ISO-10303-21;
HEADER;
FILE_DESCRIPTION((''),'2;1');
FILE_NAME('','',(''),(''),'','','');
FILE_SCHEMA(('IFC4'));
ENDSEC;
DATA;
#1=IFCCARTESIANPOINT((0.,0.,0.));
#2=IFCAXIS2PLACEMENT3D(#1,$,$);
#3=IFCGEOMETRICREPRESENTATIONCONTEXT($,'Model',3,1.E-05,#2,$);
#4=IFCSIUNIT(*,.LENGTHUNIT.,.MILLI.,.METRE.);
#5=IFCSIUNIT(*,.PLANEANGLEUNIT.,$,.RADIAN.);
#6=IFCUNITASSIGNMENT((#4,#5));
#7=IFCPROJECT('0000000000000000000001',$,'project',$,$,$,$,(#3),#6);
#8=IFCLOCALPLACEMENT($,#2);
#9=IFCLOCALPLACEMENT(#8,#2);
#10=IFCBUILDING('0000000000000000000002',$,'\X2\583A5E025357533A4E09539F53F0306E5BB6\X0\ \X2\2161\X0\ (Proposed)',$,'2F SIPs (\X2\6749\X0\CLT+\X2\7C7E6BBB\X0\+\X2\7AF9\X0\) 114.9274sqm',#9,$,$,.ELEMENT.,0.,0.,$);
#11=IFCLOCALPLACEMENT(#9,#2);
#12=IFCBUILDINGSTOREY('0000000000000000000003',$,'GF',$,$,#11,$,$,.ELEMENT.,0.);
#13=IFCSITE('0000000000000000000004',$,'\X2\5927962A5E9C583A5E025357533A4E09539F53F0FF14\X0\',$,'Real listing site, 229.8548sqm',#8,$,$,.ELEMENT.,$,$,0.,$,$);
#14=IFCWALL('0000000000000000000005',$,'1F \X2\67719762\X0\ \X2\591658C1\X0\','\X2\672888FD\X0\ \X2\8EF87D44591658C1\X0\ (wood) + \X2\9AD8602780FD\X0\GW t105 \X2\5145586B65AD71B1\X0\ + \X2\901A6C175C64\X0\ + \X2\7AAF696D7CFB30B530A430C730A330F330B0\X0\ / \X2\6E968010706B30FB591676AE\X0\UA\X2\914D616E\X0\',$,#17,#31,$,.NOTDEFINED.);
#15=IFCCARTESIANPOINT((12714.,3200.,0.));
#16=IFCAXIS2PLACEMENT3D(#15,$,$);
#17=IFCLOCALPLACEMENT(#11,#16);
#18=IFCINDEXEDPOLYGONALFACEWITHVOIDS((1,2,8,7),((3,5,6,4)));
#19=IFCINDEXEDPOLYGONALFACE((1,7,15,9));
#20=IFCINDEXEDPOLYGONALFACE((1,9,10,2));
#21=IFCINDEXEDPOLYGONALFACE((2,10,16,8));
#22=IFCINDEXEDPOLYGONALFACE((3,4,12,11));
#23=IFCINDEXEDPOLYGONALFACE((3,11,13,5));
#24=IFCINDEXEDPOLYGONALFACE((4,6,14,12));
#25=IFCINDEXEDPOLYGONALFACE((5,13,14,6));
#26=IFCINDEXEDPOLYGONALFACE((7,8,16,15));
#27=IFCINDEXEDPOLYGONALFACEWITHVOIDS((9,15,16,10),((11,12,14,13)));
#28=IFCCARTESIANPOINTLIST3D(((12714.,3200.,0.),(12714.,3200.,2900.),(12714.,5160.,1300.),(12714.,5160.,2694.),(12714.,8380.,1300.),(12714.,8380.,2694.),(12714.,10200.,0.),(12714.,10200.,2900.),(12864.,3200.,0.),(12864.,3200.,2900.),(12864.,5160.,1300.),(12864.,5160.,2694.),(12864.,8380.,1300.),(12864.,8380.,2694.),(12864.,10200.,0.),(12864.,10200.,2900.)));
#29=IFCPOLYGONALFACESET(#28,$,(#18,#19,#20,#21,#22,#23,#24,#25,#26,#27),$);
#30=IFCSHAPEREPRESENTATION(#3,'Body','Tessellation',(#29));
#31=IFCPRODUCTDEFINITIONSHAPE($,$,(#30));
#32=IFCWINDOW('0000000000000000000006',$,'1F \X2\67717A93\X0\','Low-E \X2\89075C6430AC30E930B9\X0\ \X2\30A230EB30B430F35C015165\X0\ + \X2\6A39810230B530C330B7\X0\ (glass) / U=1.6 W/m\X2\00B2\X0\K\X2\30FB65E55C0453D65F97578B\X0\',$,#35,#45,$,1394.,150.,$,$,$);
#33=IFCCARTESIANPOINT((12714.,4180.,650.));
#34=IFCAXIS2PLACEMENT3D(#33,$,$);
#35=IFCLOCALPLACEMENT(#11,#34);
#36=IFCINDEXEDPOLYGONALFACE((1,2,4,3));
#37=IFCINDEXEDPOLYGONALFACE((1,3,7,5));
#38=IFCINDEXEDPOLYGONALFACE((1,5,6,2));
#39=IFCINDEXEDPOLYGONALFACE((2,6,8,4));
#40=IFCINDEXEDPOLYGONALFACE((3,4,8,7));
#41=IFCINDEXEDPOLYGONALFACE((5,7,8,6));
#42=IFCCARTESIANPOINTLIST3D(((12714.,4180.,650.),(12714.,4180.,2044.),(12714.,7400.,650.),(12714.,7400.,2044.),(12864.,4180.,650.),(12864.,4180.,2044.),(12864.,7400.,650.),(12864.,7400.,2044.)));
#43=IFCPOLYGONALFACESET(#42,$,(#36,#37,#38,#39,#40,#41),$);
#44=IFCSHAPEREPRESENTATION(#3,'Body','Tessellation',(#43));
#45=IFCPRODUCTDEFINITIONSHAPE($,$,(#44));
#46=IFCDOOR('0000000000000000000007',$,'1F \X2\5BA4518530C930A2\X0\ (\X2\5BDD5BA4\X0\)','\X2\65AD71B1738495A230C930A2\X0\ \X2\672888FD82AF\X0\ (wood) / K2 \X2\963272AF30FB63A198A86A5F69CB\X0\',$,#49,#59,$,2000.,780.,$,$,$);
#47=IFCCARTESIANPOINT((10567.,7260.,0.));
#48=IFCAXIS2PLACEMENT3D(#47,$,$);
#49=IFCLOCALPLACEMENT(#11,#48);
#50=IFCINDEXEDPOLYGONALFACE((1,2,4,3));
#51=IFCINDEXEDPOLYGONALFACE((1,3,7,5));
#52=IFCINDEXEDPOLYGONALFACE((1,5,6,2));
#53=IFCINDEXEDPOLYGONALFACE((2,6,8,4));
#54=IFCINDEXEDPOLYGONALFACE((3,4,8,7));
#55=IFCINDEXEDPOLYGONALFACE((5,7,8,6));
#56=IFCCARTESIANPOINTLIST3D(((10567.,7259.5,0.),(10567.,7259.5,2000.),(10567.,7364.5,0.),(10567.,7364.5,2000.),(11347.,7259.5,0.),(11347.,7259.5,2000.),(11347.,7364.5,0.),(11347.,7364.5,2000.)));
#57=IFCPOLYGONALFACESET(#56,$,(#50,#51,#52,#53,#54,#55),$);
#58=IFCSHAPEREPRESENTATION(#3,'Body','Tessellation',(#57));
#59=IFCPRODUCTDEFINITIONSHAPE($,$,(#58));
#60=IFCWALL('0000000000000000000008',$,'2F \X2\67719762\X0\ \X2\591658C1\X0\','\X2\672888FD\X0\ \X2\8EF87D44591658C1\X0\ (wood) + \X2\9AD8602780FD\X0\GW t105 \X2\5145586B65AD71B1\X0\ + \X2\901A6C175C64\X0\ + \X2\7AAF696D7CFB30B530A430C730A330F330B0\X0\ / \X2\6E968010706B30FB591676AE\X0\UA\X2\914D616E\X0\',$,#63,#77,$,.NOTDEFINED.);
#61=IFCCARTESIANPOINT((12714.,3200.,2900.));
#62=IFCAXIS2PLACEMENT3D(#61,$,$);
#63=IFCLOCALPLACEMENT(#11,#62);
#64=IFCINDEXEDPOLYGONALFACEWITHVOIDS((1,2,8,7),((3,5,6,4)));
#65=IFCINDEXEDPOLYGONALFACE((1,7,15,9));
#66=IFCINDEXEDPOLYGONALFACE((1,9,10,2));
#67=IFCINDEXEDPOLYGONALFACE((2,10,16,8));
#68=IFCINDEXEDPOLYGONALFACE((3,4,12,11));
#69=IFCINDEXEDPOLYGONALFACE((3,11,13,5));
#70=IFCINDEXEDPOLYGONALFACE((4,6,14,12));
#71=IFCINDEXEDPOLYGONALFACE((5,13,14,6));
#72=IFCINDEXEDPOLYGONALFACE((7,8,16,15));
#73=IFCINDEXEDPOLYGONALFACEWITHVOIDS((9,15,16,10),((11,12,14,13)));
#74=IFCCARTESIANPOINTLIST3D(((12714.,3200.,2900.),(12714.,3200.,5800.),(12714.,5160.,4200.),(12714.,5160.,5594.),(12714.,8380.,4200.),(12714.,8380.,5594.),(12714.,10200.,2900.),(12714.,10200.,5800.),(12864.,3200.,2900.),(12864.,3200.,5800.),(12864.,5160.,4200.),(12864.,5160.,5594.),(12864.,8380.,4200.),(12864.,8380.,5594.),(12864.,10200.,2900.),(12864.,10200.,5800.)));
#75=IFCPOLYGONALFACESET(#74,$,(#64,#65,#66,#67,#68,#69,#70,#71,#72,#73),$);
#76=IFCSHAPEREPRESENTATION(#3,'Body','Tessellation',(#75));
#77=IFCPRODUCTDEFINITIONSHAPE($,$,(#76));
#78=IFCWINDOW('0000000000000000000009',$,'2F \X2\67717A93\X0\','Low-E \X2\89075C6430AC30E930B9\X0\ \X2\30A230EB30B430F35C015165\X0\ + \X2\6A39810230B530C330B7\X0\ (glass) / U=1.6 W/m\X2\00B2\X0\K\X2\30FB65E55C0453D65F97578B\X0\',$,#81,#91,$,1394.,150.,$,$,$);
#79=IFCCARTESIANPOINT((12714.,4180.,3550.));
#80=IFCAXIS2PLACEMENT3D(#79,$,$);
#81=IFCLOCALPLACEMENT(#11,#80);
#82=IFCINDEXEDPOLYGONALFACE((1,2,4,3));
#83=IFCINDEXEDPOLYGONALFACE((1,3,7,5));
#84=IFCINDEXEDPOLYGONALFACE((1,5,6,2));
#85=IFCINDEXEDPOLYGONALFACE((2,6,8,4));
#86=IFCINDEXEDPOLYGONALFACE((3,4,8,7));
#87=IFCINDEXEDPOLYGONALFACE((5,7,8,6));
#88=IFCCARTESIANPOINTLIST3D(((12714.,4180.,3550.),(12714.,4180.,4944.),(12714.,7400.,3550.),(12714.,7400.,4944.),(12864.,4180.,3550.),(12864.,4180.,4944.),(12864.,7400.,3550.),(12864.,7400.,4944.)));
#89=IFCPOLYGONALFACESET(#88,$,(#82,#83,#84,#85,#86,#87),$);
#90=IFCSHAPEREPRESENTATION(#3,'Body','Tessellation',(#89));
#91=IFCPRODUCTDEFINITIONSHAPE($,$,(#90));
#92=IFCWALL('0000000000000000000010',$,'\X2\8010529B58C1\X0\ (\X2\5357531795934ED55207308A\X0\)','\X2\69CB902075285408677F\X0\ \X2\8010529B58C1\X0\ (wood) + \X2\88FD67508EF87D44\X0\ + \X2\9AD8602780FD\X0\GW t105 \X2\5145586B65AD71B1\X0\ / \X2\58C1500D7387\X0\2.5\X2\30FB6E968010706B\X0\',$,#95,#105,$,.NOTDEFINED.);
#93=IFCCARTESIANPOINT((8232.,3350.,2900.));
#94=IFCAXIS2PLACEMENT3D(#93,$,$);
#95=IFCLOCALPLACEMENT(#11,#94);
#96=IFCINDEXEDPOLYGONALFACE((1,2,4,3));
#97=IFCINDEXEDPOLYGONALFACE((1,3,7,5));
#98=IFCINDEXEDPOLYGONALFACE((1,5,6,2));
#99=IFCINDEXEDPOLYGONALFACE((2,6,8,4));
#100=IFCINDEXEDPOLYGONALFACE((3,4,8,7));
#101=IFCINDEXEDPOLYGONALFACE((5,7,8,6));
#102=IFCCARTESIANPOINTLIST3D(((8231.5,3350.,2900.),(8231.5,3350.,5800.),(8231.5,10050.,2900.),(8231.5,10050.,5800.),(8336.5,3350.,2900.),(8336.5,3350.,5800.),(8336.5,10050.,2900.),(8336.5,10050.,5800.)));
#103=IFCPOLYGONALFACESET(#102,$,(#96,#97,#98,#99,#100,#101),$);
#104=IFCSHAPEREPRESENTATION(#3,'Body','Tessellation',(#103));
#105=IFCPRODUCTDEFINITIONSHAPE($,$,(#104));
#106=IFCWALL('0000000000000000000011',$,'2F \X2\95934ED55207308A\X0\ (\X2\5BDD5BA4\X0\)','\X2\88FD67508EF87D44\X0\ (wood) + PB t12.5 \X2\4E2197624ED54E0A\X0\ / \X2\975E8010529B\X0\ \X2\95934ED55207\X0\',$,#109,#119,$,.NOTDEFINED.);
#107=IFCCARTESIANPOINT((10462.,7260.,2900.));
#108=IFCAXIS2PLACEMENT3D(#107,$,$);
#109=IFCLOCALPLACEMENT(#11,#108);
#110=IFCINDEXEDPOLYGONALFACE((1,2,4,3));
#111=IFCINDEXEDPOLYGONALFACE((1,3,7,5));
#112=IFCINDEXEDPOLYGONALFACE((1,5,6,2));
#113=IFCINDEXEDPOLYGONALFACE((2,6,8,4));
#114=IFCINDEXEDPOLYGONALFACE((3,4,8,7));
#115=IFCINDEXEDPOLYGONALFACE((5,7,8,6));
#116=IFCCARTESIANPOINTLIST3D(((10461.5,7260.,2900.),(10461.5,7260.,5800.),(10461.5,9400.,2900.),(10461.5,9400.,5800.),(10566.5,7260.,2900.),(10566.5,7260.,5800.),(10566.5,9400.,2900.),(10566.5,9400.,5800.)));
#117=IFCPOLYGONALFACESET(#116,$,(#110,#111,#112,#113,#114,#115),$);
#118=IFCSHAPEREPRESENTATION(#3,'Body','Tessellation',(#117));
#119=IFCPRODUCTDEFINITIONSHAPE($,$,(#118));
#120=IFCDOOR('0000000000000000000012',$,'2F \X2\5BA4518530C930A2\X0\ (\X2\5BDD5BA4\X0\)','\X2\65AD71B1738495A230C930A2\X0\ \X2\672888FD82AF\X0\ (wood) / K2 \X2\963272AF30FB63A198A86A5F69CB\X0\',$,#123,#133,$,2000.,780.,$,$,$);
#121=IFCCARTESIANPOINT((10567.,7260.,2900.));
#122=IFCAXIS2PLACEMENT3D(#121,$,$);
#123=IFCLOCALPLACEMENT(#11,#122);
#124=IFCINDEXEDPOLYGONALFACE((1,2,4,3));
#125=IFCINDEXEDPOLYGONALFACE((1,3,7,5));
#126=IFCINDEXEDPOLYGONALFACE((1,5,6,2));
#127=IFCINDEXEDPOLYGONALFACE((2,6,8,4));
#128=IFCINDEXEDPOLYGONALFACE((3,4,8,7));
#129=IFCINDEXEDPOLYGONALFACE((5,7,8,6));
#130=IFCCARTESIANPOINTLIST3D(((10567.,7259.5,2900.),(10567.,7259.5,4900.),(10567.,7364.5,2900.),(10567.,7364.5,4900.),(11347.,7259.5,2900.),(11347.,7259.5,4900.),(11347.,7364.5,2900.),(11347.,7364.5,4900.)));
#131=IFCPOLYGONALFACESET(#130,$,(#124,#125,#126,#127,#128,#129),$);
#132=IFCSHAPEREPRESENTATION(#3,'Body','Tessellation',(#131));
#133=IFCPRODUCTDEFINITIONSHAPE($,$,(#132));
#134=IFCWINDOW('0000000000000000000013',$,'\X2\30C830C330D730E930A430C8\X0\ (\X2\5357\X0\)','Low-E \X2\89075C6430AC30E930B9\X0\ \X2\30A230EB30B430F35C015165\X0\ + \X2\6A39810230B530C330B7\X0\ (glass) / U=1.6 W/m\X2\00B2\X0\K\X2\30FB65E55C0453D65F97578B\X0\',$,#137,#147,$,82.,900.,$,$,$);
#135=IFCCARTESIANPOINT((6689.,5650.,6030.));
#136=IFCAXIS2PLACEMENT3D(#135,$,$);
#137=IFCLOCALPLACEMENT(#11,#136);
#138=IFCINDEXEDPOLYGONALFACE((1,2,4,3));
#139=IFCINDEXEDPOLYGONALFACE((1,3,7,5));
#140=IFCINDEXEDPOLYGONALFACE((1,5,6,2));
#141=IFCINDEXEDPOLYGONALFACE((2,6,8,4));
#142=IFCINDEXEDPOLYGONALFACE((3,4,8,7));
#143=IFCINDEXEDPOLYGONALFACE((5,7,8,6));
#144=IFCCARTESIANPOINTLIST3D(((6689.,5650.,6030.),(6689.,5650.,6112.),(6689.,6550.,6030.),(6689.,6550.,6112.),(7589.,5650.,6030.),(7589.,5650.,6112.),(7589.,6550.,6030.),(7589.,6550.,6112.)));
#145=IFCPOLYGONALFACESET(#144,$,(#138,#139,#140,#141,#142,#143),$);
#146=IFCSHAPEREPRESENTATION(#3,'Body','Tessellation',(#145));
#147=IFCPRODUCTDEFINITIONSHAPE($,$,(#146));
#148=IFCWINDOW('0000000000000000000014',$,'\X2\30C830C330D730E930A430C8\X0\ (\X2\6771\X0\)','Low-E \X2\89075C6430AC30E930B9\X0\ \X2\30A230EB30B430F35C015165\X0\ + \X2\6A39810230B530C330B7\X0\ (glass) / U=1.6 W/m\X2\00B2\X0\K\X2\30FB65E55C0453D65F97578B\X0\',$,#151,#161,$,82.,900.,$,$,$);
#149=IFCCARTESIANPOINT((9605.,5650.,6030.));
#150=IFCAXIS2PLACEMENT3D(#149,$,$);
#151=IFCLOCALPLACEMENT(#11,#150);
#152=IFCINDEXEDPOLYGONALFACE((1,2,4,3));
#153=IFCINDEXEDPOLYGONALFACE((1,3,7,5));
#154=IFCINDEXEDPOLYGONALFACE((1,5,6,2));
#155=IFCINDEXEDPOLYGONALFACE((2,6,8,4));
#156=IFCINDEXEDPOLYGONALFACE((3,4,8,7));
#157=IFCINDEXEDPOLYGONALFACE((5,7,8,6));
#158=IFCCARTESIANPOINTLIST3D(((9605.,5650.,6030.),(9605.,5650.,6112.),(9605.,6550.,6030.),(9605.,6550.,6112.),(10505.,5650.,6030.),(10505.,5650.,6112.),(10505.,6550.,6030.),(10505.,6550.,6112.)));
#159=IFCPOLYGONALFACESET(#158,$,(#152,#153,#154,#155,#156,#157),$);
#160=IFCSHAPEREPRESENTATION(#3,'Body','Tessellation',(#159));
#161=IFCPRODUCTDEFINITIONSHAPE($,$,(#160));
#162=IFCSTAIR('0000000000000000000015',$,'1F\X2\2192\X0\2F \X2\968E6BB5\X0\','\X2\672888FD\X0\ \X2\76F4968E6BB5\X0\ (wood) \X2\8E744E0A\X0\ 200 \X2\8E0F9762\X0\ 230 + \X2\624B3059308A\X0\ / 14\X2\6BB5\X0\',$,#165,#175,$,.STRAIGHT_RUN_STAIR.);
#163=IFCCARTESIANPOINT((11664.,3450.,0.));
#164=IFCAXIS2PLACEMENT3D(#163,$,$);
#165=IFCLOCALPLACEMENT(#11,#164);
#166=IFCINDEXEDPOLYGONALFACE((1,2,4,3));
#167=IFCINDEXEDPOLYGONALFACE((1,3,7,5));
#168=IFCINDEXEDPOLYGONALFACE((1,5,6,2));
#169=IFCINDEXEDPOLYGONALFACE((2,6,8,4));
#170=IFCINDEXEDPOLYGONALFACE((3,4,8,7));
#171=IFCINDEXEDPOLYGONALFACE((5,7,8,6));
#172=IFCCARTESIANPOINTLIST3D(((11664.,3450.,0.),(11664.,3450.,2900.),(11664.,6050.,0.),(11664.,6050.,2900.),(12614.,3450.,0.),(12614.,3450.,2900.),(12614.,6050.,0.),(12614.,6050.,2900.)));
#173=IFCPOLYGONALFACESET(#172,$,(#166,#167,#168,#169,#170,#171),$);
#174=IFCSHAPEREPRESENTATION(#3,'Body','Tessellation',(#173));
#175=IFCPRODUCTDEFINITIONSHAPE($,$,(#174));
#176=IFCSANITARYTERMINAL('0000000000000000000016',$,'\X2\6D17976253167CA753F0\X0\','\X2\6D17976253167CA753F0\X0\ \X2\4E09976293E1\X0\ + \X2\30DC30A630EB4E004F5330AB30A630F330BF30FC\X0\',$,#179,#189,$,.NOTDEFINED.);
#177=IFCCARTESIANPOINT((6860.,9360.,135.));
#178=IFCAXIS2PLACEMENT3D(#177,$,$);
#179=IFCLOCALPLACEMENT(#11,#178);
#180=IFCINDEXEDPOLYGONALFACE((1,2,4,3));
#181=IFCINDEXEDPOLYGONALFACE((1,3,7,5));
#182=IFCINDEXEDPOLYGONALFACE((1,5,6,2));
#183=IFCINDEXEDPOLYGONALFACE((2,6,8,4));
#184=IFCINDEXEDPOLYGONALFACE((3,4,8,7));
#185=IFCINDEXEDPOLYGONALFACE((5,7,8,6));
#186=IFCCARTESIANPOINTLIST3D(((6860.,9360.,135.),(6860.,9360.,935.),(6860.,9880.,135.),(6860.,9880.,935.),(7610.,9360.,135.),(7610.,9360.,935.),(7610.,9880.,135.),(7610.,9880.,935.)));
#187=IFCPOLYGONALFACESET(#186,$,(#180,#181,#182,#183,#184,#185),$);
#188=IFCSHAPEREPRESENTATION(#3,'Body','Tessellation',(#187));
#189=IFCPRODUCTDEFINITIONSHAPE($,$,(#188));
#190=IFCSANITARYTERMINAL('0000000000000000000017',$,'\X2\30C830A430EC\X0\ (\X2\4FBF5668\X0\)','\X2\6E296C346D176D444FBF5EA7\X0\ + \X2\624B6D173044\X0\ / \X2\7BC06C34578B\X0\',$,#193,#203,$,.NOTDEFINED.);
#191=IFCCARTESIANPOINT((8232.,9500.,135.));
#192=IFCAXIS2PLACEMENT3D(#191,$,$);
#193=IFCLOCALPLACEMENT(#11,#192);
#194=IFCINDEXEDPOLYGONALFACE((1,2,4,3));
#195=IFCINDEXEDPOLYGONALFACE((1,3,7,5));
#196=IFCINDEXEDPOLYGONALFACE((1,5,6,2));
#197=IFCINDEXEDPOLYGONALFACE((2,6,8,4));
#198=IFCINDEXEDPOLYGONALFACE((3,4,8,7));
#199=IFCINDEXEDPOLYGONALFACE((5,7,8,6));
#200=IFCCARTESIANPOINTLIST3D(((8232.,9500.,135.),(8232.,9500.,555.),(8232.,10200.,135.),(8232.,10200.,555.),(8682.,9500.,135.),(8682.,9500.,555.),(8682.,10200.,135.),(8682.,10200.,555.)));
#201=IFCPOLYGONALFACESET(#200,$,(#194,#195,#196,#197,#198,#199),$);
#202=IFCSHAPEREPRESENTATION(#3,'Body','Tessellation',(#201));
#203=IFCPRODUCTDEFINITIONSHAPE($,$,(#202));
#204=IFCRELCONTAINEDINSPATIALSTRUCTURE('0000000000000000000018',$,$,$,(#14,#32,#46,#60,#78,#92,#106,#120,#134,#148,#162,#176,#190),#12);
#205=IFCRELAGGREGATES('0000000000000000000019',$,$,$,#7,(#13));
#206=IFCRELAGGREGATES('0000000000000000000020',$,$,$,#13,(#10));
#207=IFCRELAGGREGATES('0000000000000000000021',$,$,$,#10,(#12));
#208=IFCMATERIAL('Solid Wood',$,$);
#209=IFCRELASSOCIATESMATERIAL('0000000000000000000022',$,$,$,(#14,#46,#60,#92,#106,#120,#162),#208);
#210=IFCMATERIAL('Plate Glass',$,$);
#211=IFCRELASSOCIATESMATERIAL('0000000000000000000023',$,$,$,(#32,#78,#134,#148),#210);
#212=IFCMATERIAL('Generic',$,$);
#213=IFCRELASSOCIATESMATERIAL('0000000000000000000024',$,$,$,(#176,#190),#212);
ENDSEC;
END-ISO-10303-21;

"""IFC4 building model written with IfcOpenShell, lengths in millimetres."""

from ifc_helpers import new_model, si_unit, frame, frame_2d, origin, place, context, project, spatial, rectangle, extrude, material, element, fill, save


model = new_model("IFC4")

# Units and contexts
model_context = context("Model", 3, precision=1e-05, world=origin())
ifc_project = project(units=[si_unit("LENGTHUNIT", "METRE", prefix="MILLI"), si_unit("PLANEANGLEUNIT", "RADIAN")], contexts=[model_context])

# Site, building, storey
site_placement = place(None, origin())
site = spatial("IfcSite", under=ifc_project, at=site_placement, Name="大阪府堺市南区三原台４", ObjectType="Real listing site, 229.8548sqm", CompositionType="ELEMENT", RefElevation=0.0)
building_placement = place(site_placement, origin())
building = spatial("IfcBuilding", under=site, at=building_placement, Name="堺市南区三原台の家 Ⅱ (Proposed)", ObjectType="2F SIPs (杉CLT+籾殻+竹) 114.9274sqm", CompositionType="ELEMENT", ElevationOfRefHeight=0.0, ElevationOfTerrain=0.0)
storey_placement = place(building_placement, origin())
storey = spatial("IfcBuildingStorey", under=building, at=storey_placement, Name="GF", CompositionType="ELEMENT", Elevation=0.0)

# Wall, opening, window
ifc_material_1 = material(Name="Solid Wood")
wall_1_placement = place(storey_placement, frame((12714.0, 3200.0, 0.0)))
wall_1 = element("IfcWall", 1, at=wall_1_placement, inside=storey, material=ifc_material_1, Name="1F 東面 外壁", Description="木製 軸組外壁 (wood) + 高性能GW t105 充填断熱 + 通気層 + 窯業系サイディング / 準耐火・外皮UA配慮", PredefinedType="NOTDEFINED", context=model_context, shape_type="SweptSolid", body=[
    extrude(rectangle(XDim=150.0, YDim=7000.0, at=frame_2d((75.0, 3500.0))), frame((12714.0, 3200.0, 0.0)), (0.0, 0.0, 1.0), 2900.0),
])
opening_1_placement = place(storey_placement, frame((12714.0, 4180.0, 650.0)))
opening_1 = element("IfcOpeningElement", 2, at=opening_1_placement, cuts=wall_1, PredefinedType="NOTDEFINED", context=model_context, shape_type="SweptSolid", body=[
    extrude(rectangle(XDim=150.0, YDim=3220.0, at=frame_2d((75.0, 1610.0))), frame((12714.0, 4180.0, 650.0)), (0.0, 0.0, 1.0), 1394.0),
])
ifc_material_2 = material(Name="Plate Glass")
window_1_placement = place(storey_placement, frame((12714.0, 4180.0, 650.0)))
window_1 = element("IfcWindow", 3, at=window_1_placement, inside=storey, material=ifc_material_2, Name="1F 東窓", Description="Low-E 複層ガラス アルゴン封入 + 樹脂サッシ (glass) / U=1.6 W/m²K・日射取得型", OverallHeight=1394.0, OverallWidth=150.0, context=model_context, shape_type="SweptSolid", body=[
    extrude(rectangle(XDim=150.0, YDim=3220.0, at=frame_2d((75.0, 1610.0))), frame((12714.0, 4180.0, 650.0)), (0.0, 0.0, 1.0), 1394.0),
])
fill(opening_1, window_1)

# Door
door_1_placement = place(storey_placement, frame((10567.0, 7260.0, 0.0)))
element("IfcDoor", 4, at=door_1_placement, inside=storey, material=ifc_material_1, Name="1F 室内ドア (寝室)", Description="断熱玄関ドア 木製芯 (wood) / K2 防犯・採風機構", OverallHeight=2000.0, OverallWidth=780.0, context=model_context, shape_type="SweptSolid", body=[
    extrude(rectangle(XDim=780.0, YDim=105.0, at=frame_2d((390.0, 52.0))), frame((10567.0, 7260.0, 0.0)), (0.0, 0.0, 1.0), 2000.0),
])

# Wall, opening, window
wall_2_placement = place(storey_placement, frame((12714.0, 3200.0, 2900.0)))
wall_2 = element("IfcWall", 5, at=wall_2_placement, inside=storey, material=ifc_material_1, Name="2F 東面 外壁", Description="木製 軸組外壁 (wood) + 高性能GW t105 充填断熱 + 通気層 + 窯業系サイディング / 準耐火・外皮UA配慮", PredefinedType="NOTDEFINED", context=model_context, shape_type="SweptSolid", body=[
    extrude(rectangle(XDim=150.0, YDim=7000.0, at=frame_2d((75.0, 3500.0))), frame((12714.0, 3200.0, 2900.0)), (0.0, 0.0, 1.0), 2900.0),
])
opening_2_placement = place(storey_placement, frame((12714.0, 4180.0, 3550.0)))
opening_2 = element("IfcOpeningElement", 6, at=opening_2_placement, cuts=wall_2, PredefinedType="NOTDEFINED", context=model_context, shape_type="SweptSolid", body=[
    extrude(rectangle(XDim=150.0, YDim=3220.0, at=frame_2d((75.0, 1610.0))), frame((12714.0, 4180.0, 3550.0)), (0.0, 0.0, 1.0), 1394.0),
])
window_2_placement = place(storey_placement, frame((12714.0, 4180.0, 3550.0)))
window_2 = element("IfcWindow", 7, at=window_2_placement, inside=storey, material=ifc_material_2, Name="2F 東窓", Description="Low-E 複層ガラス アルゴン封入 + 樹脂サッシ (glass) / U=1.6 W/m²K・日射取得型", OverallHeight=1394.0, OverallWidth=150.0, context=model_context, shape_type="SweptSolid", body=[
    extrude(rectangle(XDim=150.0, YDim=3220.0, at=frame_2d((75.0, 1610.0))), frame((12714.0, 4180.0, 3550.0)), (0.0, 0.0, 1.0), 1394.0),
])
fill(opening_2, window_2)

# Walls
wall_3_placement = place(storey_placement, frame((8232.0, 3350.0, 2900.0)))
element("IfcWall", 8, at=wall_3_placement, inside=storey, material=ifc_material_1, Name="耐力壁 (南北間仕切り)", Description="構造用合板 耐力壁 (wood) + 製材軸組 + 高性能GW t105 充填断熱 / 壁倍率2.5・準耐火", PredefinedType="NOTDEFINED", context=model_context, shape_type="SweptSolid", body=[
    extrude(rectangle(XDim=105.0, YDim=6700.0, at=frame_2d((52.0, 3350.0))), frame((8232.0, 3350.0, 2900.0)), (0.0, 0.0, 1.0), 2900.0),
])
wall_4_placement = place(storey_placement, frame((10462.0, 7260.0, 2900.0)))
element("IfcWall", 9, at=wall_4_placement, inside=storey, material=ifc_material_1, Name="2F 間仕切り (寝室)", Description="製材軸組 (wood) + PB t12.5 両面仕上 / 非耐力 間仕切", PredefinedType="NOTDEFINED", context=model_context, shape_type="SweptSolid", body=[
    extrude(rectangle(XDim=105.0, YDim=2140.0, at=frame_2d((52.0, 1070.0))), frame((10462.0, 7260.0, 2900.0)), (0.0, 0.0, 1.0), 2900.0),
])

# Door
door_2_placement = place(storey_placement, frame((10567.0, 7260.0, 2900.0)))
element("IfcDoor", 10, at=door_2_placement, inside=storey, material=ifc_material_1, Name="2F 室内ドア (寝室)", Description="断熱玄関ドア 木製芯 (wood) / K2 防犯・採風機構", OverallHeight=2000.0, OverallWidth=780.0, context=model_context, shape_type="SweptSolid", body=[
    extrude(rectangle(XDim=780.0, YDim=105.0, at=frame_2d((390.0, 52.0))), frame((10567.0, 7260.0, 2900.0)), (0.0, 0.0, 1.0), 2000.0),
])

# Windows
window_3_placement = place(storey_placement, frame((6689.0, 5650.0, 6030.0)))
element("IfcWindow", 11, at=window_3_placement, inside=storey, material=ifc_material_2, Name="トップライト (南)", Description="Low-E 複層ガラス アルゴン封入 + 樹脂サッシ (glass) / U=1.6 W/m²K・日射取得型", OverallHeight=82.0, OverallWidth=900.0, context=model_context, shape_type="SweptSolid", body=[
    extrude(rectangle(XDim=900.0, YDim=900.0, at=frame_2d((450.0, 450.0))), frame((6689.0, 5650.0, 6030.0)), (0.0, 0.0, 1.0), 82.0),
])
window_4_placement = place(storey_placement, frame((9605.0, 5650.0, 6030.0)))
element("IfcWindow", 12, at=window_4_placement, inside=storey, material=ifc_material_2, Name="トップライト (東)", Description="Low-E 複層ガラス アルゴン封入 + 樹脂サッシ (glass) / U=1.6 W/m²K・日射取得型", OverallHeight=82.0, OverallWidth=900.0, context=model_context, shape_type="SweptSolid", body=[
    extrude(rectangle(XDim=900.0, YDim=900.0, at=frame_2d((450.0, 450.0))), frame((9605.0, 5650.0, 6030.0)), (0.0, 0.0, 1.0), 82.0),
])

# Stair
stair_placement = place(storey_placement, frame((11664.0, 3450.0, 0.0)))
element("IfcStair", 13, at=stair_placement, inside=storey, material=ifc_material_1, Name="1F→2F 階段", Description="木製 直階段 (wood) 蹴上 200 踏面 230 + 手すり / 14段", PredefinedType="STRAIGHT_RUN_STAIR", context=model_context, shape_type="SweptSolid", body=[
    extrude(rectangle(XDim=950.0, YDim=2600.0, at=frame_2d((475.0, 1300.0))), frame((11664.0, 3450.0, 0.0)), (0.0, 0.0, 1.0), 2900.0),
])

# Sanitary terminals
ifc_material_3 = material(Name="Generic")
sanitary_terminal_1_placement = place(storey_placement, frame((6860.0, 9360.0, 135.0)))
element("IfcSanitaryTerminal", 14, at=sanitary_terminal_1_placement, inside=storey, material=ifc_material_3, Name="洗面化粧台", Description="洗面化粧台 三面鏡 + ボウル一体カウンター", PredefinedType="NOTDEFINED", context=model_context, shape_type="SweptSolid", body=[
    extrude(rectangle(XDim=750.0, YDim=520.0, at=frame_2d((375.0, 260.0))), frame((6860.0, 9360.0, 135.0)), (0.0, 0.0, 1.0), 800.0),
])
sanitary_terminal_2_placement = place(storey_placement, frame((8232.0, 9500.0, 135.0)))
element("IfcSanitaryTerminal", 15, at=sanitary_terminal_2_placement, inside=storey, material=ifc_material_3, Name="トイレ (便器)", Description="温水洗浄便座 + 手洗い / 節水型", PredefinedType="NOTDEFINED", context=model_context, shape_type="SweptSolid", body=[
    extrude(rectangle(XDim=450.0, YDim=700.0, at=frame_2d((225.0, 350.0))), frame((8232.0, 9500.0, 135.0)), (0.0, 0.0, 1.0), 420.0),
])

save(model, "model.ifc")
